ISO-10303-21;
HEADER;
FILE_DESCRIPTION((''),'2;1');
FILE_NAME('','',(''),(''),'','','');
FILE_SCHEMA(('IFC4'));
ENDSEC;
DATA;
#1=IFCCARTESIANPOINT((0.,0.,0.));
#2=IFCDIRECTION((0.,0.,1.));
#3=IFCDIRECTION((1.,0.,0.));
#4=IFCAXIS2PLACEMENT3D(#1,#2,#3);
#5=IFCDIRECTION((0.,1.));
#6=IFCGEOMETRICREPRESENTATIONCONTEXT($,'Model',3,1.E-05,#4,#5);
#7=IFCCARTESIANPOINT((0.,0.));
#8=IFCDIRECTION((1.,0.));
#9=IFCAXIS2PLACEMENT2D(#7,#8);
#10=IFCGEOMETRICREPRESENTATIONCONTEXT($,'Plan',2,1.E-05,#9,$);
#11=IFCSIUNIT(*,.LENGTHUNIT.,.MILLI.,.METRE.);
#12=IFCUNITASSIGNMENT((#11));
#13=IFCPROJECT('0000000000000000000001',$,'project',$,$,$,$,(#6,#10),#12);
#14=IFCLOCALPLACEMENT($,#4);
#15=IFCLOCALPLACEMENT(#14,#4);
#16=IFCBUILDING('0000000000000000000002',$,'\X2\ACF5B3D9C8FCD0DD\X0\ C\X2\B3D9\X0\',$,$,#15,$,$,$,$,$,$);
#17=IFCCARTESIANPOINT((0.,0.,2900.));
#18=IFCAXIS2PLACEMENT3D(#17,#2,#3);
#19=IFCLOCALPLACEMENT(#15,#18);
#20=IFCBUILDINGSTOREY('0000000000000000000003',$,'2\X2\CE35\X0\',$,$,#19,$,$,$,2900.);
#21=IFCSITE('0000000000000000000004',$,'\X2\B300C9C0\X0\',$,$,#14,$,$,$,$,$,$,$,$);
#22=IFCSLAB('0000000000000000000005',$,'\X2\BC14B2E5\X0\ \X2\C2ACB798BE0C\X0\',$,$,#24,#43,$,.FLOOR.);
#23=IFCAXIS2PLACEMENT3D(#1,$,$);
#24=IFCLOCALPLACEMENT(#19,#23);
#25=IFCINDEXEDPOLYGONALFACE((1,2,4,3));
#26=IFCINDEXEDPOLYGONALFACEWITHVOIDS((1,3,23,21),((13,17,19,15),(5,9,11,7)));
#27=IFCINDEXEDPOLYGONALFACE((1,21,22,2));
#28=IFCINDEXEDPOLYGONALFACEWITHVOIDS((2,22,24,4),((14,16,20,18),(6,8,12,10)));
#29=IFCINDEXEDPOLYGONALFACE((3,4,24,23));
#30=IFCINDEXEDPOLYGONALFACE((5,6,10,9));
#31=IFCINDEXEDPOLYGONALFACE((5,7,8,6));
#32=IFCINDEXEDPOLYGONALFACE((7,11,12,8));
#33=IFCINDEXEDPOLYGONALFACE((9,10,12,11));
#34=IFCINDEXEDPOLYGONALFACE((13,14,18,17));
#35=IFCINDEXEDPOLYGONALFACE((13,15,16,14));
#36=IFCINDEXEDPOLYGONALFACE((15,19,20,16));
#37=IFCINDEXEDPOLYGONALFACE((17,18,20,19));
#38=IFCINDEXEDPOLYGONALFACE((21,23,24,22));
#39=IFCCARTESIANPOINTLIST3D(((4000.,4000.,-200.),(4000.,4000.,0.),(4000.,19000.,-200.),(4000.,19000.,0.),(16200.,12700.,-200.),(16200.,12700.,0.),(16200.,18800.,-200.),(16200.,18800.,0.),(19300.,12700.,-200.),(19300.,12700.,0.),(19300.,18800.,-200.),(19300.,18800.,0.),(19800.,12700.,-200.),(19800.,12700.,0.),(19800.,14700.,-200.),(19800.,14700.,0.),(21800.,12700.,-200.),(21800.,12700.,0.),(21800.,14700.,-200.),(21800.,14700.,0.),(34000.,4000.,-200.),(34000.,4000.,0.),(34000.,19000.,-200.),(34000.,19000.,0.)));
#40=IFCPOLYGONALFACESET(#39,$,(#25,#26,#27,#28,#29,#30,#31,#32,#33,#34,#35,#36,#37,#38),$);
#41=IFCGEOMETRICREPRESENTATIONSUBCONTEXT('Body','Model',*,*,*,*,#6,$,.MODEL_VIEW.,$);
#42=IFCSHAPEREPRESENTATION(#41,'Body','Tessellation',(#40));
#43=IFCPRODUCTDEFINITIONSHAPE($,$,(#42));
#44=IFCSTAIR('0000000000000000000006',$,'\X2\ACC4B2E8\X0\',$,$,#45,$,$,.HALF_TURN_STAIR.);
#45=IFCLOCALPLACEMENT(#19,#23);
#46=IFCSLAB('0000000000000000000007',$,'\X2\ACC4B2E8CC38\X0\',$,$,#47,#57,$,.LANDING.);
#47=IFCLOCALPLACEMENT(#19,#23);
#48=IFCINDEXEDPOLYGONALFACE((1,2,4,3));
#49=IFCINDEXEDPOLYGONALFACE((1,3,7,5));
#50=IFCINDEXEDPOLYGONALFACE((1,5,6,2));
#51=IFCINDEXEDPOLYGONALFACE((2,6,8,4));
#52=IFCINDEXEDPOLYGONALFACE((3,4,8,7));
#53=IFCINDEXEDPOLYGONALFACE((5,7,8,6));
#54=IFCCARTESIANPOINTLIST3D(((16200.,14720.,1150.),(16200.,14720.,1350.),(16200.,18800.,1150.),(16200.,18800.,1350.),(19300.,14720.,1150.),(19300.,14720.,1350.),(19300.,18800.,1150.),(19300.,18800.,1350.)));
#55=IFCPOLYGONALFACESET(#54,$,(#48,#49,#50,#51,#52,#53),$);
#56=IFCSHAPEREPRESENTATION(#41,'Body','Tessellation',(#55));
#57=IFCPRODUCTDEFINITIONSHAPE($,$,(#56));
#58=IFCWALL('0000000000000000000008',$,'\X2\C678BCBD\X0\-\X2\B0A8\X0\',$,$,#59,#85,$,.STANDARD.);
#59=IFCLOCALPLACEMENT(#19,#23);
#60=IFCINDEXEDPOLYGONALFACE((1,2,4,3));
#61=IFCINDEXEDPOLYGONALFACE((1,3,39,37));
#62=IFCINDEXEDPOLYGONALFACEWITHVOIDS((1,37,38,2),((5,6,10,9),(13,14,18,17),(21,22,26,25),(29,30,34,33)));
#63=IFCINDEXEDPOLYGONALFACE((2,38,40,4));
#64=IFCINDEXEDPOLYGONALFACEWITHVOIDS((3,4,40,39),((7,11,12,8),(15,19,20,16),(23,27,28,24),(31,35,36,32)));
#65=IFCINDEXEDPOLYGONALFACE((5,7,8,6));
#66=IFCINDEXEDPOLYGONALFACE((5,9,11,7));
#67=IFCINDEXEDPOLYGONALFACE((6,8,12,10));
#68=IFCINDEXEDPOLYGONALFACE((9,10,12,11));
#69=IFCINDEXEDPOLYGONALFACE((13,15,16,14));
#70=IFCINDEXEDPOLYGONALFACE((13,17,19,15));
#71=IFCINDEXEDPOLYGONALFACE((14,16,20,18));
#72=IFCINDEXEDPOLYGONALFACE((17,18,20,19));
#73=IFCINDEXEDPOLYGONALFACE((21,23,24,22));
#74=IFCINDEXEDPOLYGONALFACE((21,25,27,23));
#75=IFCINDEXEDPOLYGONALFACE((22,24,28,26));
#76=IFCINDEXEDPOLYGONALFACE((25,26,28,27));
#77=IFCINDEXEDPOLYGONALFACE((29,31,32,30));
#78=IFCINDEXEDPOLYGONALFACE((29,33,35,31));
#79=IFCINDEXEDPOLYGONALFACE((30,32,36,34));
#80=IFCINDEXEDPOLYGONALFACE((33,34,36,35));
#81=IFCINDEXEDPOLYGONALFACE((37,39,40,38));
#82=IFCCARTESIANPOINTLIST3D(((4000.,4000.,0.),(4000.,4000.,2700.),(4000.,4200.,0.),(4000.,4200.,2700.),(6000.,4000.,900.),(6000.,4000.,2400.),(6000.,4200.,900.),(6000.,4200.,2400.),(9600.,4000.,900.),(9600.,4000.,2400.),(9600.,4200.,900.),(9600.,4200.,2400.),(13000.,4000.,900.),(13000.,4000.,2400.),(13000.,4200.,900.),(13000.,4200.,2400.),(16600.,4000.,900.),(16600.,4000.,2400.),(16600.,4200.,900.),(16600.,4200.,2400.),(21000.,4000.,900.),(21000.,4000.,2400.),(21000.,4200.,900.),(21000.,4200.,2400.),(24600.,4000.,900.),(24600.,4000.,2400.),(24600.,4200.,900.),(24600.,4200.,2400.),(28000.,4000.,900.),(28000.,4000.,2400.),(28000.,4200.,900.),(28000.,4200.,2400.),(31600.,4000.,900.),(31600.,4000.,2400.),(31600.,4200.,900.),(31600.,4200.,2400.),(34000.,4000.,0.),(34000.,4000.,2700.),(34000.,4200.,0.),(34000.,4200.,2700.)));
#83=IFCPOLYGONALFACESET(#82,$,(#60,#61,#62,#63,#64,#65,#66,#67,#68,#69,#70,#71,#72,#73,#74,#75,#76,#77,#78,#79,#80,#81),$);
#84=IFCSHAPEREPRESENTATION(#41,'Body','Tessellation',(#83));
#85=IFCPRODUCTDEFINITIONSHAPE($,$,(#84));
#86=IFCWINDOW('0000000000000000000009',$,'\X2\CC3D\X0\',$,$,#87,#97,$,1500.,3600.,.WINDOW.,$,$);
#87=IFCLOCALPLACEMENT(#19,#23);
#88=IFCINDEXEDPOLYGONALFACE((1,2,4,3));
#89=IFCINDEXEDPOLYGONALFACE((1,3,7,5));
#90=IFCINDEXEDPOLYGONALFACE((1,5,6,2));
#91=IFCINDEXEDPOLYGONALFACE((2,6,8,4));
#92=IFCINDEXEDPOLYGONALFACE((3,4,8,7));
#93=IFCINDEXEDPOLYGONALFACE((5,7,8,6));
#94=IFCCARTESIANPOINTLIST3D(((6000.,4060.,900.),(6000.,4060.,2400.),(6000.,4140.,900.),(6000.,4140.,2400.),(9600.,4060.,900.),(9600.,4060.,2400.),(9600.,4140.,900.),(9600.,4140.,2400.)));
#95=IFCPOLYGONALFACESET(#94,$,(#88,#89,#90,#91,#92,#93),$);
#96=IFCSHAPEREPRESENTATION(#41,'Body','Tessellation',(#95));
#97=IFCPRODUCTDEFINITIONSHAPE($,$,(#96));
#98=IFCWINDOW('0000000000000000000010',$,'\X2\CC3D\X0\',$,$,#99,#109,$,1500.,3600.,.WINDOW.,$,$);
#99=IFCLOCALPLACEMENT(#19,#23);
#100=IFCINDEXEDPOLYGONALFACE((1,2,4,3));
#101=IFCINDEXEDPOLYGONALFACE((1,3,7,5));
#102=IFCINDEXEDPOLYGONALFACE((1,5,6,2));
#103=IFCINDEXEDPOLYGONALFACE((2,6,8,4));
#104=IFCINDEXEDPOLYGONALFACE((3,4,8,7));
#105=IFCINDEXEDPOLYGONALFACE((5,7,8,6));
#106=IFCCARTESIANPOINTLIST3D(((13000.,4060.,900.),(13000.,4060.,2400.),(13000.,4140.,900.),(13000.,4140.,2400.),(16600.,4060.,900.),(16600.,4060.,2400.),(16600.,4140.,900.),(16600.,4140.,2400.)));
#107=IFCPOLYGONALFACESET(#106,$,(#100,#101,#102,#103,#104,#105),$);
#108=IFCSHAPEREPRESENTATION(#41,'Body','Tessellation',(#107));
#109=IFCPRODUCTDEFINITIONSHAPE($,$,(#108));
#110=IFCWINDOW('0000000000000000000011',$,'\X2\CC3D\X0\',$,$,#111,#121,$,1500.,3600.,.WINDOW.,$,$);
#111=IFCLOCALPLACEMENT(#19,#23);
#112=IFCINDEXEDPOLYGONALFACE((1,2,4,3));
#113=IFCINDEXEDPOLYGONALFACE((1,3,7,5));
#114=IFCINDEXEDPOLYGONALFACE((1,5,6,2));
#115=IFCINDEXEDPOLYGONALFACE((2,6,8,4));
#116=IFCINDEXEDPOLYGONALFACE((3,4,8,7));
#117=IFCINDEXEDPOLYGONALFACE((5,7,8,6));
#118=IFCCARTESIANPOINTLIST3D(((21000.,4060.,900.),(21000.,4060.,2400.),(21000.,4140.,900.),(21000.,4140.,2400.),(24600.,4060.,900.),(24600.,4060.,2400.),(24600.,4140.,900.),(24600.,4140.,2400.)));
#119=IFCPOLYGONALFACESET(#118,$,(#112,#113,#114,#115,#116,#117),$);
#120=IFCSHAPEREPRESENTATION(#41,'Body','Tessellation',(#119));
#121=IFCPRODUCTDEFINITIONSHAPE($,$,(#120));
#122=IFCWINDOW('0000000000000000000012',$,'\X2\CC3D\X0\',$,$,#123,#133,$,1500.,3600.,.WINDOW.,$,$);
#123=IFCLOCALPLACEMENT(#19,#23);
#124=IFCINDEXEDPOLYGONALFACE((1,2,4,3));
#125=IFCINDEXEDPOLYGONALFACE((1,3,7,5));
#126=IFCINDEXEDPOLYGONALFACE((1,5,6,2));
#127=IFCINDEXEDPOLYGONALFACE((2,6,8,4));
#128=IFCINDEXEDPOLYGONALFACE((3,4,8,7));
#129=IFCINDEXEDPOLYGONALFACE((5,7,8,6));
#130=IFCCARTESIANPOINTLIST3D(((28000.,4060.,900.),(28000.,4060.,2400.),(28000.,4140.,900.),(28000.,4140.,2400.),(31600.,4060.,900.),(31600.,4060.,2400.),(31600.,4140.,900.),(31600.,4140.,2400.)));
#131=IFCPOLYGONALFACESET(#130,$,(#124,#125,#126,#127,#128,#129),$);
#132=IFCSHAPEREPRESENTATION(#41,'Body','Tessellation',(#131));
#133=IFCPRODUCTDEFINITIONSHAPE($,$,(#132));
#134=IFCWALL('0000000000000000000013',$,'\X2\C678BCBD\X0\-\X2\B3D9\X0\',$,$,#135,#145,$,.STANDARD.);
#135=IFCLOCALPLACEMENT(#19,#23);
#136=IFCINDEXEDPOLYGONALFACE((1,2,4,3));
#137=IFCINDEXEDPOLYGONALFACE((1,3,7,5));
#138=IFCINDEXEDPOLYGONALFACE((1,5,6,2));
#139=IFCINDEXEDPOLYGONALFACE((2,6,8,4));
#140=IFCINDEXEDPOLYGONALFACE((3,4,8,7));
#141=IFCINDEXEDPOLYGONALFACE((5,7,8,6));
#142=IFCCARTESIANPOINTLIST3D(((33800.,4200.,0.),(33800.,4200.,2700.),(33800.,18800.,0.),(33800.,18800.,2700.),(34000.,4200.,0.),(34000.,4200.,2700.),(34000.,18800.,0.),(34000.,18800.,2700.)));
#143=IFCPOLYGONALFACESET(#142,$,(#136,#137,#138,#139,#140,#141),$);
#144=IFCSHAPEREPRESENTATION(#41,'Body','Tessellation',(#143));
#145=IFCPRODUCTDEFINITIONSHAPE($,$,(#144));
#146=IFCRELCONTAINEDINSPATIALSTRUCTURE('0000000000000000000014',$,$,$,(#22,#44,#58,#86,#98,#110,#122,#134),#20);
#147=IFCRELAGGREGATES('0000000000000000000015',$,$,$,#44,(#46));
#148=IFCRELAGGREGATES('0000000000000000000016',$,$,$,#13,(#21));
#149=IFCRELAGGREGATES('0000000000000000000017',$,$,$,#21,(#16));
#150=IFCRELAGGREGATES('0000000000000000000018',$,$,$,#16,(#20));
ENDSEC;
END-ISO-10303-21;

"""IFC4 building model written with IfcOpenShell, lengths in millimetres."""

from ifc_helpers import new_model, si_unit, direction, frame, origin_with_axes, origin_2d_with_axis, place, context, subcontext, project, spatial, polyline, outline, extrude, element, fill, aggregate, save


model = new_model("IFC4")

# Units and contexts
model_context = context("Model", 3, precision=1e-05, world=origin_with_axes(), true_north=direction((0.0, 1.0)))
plan_context = context("Plan", 2, precision=1e-05, world=origin_2d_with_axis())
body_context = subcontext(model_context, "Body", "Model", "MODEL_VIEW")
ifc_project = project(units=[si_unit("LENGTHUNIT", "METRE", prefix="MILLI")], contexts=[model_context, plan_context])

# Site, building, storey
site_placement = place(None, origin_with_axes())
site = spatial("IfcSite", under=ifc_project, at=site_placement, Name="대지")
building_placement = place(site_placement, origin_with_axes())
building = spatial("IfcBuilding", under=site, at=building_placement, Name="공동주택 C동")
storey_placement = place(building_placement, frame((0.0, 0.0, 2900.0), z_axis=(0.0, 0.0, 1.0), x_axis=(1.0, 0.0, 0.0)))
storey = spatial("IfcBuildingStorey", under=building, at=storey_placement, Name="2층", Elevation=2900.0)

# Slab
slab_1_placement = place(storey_placement, origin_with_axes())
element("IfcSlab", 1, at=slab_1_placement, inside=storey, Name="바닥 슬래브", PredefinedType="FLOOR", context=body_context, shape_type="SweptSolid", body=[
    extrude(outline(polyline([(4000.0, 4000.0), (34000.0, 4000.0), (34000.0, 19000.0), (4000.0, 19000.0), (4000.0, 4000.0)]), holes=[polyline([(16200.0, 12700.0), (19300.0, 12700.0), (19300.0, 18800.0), (16200.0, 18800.0), (16200.0, 12700.0)]), polyline([(19800.0, 12700.0), (21800.0, 12700.0), (21800.0, 14700.0), (19800.0, 14700.0), (19800.0, 12700.0)])]), frame((0.0, 0.0, -200.0), z_axis=(0.0, 0.0, 1.0), x_axis=(1.0, 0.0, 0.0)), (0.0, 0.0, 1.0), 200.0),
])

# Stair, slab
stair_placement = place(storey_placement, origin_with_axes())
stair = element("IfcStair", 2, at=stair_placement, inside=storey, Name="계단", PredefinedType="HALF_TURN_STAIR")
slab_2_placement = place(stair_placement, origin_with_axes())
slab_2 = element("IfcSlab", 3, at=slab_2_placement, Name="계단참", PredefinedType="LANDING", context=body_context, shape_type="SweptSolid", body=[
    extrude(outline(polyline([(16200.0, 14720.0), (19300.0, 14720.0), (19300.0, 18800.0), (16200.0, 18800.0), (16200.0, 14720.0)])), frame((0.0, 0.0, 1150.0), z_axis=(0.0, 0.0, 1.0), x_axis=(1.0, 0.0, 0.0)), (0.0, 0.0, 1.0), 200.0),
])

# Wall, openings, windows
wall_1_placement = place(storey_placement, origin_with_axes())
wall_1 = element("IfcWall", 4, at=wall_1_placement, inside=storey, Name="외벽-남", PredefinedType="STANDARD", context=body_context, shape_type="SweptSolid", body=[
    extrude(outline(polyline([(4000.0, 4200.0), (34000.0, 4200.0), (34000.0, 4000.0), (4000.0, 4000.0), (4000.0, 4200.0)])), origin_with_axes(), (0.0, 0.0, 1.0), 2700.0),
])
opening_1_placement = place(storey_placement, origin_with_axes())
opening_1 = element("IfcOpeningElement", 5, at=opening_1_placement, cuts=wall_1, PredefinedType="OPENING", context=body_context, shape_type="SweptSolid", body=[
    extrude(outline(polyline([(6000.0, 3950.0), (9600.0, 3950.0), (9600.0, 4250.0), (6000.0, 4250.0), (6000.0, 3950.0)])), frame((0.0, 0.0, 900.0), z_axis=(0.0, 0.0, 1.0), x_axis=(1.0, 0.0, 0.0)), (0.0, 0.0, 1.0), 1500.0),
])
opening_2_placement = place(storey_placement, origin_with_axes())
opening_2 = element("IfcOpeningElement", 6, at=opening_2_placement, cuts=wall_1, PredefinedType="OPENING", context=body_context, shape_type="SweptSolid", body=[
    extrude(outline(polyline([(13000.0, 3950.0), (16600.0, 3950.0), (16600.0, 4250.0), (13000.0, 4250.0), (13000.0, 3950.0)])), frame((0.0, 0.0, 900.0), z_axis=(0.0, 0.0, 1.0), x_axis=(1.0, 0.0, 0.0)), (0.0, 0.0, 1.0), 1500.0),
])
opening_3_placement = place(storey_placement, origin_with_axes())
opening_3 = element("IfcOpeningElement", 7, at=opening_3_placement, cuts=wall_1, PredefinedType="OPENING", context=body_context, shape_type="SweptSolid", body=[
    extrude(outline(polyline([(21000.0, 3950.0), (24600.0, 3950.0), (24600.0, 4250.0), (21000.0, 4250.0), (21000.0, 3950.0)])), frame((0.0, 0.0, 900.0), z_axis=(0.0, 0.0, 1.0), x_axis=(1.0, 0.0, 0.0)), (0.0, 0.0, 1.0), 1500.0),
])
opening_4_placement = place(storey_placement, origin_with_axes())
opening_4 = element("IfcOpeningElement", 8, at=opening_4_placement, cuts=wall_1, PredefinedType="OPENING", context=body_context, shape_type="SweptSolid", body=[
    extrude(outline(polyline([(28000.0, 3950.0), (31600.0, 3950.0), (31600.0, 4250.0), (28000.0, 4250.0), (28000.0, 3950.0)])), frame((0.0, 0.0, 900.0), z_axis=(0.0, 0.0, 1.0), x_axis=(1.0, 0.0, 0.0)), (0.0, 0.0, 1.0), 1500.0),
])
window_1_placement = place(storey_placement, origin_with_axes())
window_1 = element("IfcWindow", 9, at=window_1_placement, inside=storey, Name="창", OverallHeight=1500.0, OverallWidth=3600.0, PredefinedType="WINDOW", context=body_context, shape_type="SweptSolid", body=[
    extrude(outline(polyline([(6000.0, 4060.0), (9600.0, 4060.0), (9600.0, 4140.0), (6000.0, 4140.0), (6000.0, 4060.0)])), frame((0.0, 0.0, 900.0), z_axis=(0.0, 0.0, 1.0), x_axis=(1.0, 0.0, 0.0)), (0.0, 0.0, 1.0), 1500.0),
])
fill(opening_1, window_1)
window_2_placement = place(storey_placement, origin_with_axes())
window_2 = element("IfcWindow", 10, at=window_2_placement, inside=storey, Name="창", OverallHeight=1500.0, OverallWidth=3600.0, PredefinedType="WINDOW", context=body_context, shape_type="SweptSolid", body=[
    extrude(outline(polyline([(13000.0, 4060.0), (16600.0, 4060.0), (16600.0, 4140.0), (13000.0, 4140.0), (13000.0, 4060.0)])), frame((0.0, 0.0, 900.0), z_axis=(0.0, 0.0, 1.0), x_axis=(1.0, 0.0, 0.0)), (0.0, 0.0, 1.0), 1500.0),
])
fill(opening_2, window_2)
window_3_placement = place(storey_placement, origin_with_axes())
window_3 = element("IfcWindow", 11, at=window_3_placement, inside=storey, Name="창", OverallHeight=1500.0, OverallWidth=3600.0, PredefinedType="WINDOW", context=body_context, shape_type="SweptSolid", body=[
    extrude(outline(polyline([(21000.0, 4060.0), (24600.0, 4060.0), (24600.0, 4140.0), (21000.0, 4140.0), (21000.0, 4060.0)])), frame((0.0, 0.0, 900.0), z_axis=(0.0, 0.0, 1.0), x_axis=(1.0, 0.0, 0.0)), (0.0, 0.0, 1.0), 1500.0),
])
fill(opening_3, window_3)
window_4_placement = place(storey_placement, origin_with_axes())
window_4 = element("IfcWindow", 12, at=window_4_placement, inside=storey, Name="창", OverallHeight=1500.0, OverallWidth=3600.0, PredefinedType="WINDOW", context=body_context, shape_type="SweptSolid", body=[
    extrude(outline(polyline([(28000.0, 4060.0), (31600.0, 4060.0), (31600.0, 4140.0), (28000.0, 4140.0), (28000.0, 4060.0)])), frame((0.0, 0.0, 900.0), z_axis=(0.0, 0.0, 1.0), x_axis=(1.0, 0.0, 0.0)), (0.0, 0.0, 1.0), 1500.0),
])
fill(opening_4, window_4)

# Wall
wall_2_placement = place(storey_placement, origin_with_axes())
element("IfcWall", 13, at=wall_2_placement, inside=storey, Name="외벽-동", PredefinedType="STANDARD", context=body_context, shape_type="SweptSolid", body=[
    extrude(outline(polyline([(33800.0, 4200.0), (33800.0, 18800.0), (34000.0, 18800.0), (34000.0, 4200.0), (33800.0, 4200.0)])), origin_with_axes(), (0.0, 0.0, 1.0), 2700.0),
])

aggregate(stair, [slab_2])

save(model, "model.ifc")
